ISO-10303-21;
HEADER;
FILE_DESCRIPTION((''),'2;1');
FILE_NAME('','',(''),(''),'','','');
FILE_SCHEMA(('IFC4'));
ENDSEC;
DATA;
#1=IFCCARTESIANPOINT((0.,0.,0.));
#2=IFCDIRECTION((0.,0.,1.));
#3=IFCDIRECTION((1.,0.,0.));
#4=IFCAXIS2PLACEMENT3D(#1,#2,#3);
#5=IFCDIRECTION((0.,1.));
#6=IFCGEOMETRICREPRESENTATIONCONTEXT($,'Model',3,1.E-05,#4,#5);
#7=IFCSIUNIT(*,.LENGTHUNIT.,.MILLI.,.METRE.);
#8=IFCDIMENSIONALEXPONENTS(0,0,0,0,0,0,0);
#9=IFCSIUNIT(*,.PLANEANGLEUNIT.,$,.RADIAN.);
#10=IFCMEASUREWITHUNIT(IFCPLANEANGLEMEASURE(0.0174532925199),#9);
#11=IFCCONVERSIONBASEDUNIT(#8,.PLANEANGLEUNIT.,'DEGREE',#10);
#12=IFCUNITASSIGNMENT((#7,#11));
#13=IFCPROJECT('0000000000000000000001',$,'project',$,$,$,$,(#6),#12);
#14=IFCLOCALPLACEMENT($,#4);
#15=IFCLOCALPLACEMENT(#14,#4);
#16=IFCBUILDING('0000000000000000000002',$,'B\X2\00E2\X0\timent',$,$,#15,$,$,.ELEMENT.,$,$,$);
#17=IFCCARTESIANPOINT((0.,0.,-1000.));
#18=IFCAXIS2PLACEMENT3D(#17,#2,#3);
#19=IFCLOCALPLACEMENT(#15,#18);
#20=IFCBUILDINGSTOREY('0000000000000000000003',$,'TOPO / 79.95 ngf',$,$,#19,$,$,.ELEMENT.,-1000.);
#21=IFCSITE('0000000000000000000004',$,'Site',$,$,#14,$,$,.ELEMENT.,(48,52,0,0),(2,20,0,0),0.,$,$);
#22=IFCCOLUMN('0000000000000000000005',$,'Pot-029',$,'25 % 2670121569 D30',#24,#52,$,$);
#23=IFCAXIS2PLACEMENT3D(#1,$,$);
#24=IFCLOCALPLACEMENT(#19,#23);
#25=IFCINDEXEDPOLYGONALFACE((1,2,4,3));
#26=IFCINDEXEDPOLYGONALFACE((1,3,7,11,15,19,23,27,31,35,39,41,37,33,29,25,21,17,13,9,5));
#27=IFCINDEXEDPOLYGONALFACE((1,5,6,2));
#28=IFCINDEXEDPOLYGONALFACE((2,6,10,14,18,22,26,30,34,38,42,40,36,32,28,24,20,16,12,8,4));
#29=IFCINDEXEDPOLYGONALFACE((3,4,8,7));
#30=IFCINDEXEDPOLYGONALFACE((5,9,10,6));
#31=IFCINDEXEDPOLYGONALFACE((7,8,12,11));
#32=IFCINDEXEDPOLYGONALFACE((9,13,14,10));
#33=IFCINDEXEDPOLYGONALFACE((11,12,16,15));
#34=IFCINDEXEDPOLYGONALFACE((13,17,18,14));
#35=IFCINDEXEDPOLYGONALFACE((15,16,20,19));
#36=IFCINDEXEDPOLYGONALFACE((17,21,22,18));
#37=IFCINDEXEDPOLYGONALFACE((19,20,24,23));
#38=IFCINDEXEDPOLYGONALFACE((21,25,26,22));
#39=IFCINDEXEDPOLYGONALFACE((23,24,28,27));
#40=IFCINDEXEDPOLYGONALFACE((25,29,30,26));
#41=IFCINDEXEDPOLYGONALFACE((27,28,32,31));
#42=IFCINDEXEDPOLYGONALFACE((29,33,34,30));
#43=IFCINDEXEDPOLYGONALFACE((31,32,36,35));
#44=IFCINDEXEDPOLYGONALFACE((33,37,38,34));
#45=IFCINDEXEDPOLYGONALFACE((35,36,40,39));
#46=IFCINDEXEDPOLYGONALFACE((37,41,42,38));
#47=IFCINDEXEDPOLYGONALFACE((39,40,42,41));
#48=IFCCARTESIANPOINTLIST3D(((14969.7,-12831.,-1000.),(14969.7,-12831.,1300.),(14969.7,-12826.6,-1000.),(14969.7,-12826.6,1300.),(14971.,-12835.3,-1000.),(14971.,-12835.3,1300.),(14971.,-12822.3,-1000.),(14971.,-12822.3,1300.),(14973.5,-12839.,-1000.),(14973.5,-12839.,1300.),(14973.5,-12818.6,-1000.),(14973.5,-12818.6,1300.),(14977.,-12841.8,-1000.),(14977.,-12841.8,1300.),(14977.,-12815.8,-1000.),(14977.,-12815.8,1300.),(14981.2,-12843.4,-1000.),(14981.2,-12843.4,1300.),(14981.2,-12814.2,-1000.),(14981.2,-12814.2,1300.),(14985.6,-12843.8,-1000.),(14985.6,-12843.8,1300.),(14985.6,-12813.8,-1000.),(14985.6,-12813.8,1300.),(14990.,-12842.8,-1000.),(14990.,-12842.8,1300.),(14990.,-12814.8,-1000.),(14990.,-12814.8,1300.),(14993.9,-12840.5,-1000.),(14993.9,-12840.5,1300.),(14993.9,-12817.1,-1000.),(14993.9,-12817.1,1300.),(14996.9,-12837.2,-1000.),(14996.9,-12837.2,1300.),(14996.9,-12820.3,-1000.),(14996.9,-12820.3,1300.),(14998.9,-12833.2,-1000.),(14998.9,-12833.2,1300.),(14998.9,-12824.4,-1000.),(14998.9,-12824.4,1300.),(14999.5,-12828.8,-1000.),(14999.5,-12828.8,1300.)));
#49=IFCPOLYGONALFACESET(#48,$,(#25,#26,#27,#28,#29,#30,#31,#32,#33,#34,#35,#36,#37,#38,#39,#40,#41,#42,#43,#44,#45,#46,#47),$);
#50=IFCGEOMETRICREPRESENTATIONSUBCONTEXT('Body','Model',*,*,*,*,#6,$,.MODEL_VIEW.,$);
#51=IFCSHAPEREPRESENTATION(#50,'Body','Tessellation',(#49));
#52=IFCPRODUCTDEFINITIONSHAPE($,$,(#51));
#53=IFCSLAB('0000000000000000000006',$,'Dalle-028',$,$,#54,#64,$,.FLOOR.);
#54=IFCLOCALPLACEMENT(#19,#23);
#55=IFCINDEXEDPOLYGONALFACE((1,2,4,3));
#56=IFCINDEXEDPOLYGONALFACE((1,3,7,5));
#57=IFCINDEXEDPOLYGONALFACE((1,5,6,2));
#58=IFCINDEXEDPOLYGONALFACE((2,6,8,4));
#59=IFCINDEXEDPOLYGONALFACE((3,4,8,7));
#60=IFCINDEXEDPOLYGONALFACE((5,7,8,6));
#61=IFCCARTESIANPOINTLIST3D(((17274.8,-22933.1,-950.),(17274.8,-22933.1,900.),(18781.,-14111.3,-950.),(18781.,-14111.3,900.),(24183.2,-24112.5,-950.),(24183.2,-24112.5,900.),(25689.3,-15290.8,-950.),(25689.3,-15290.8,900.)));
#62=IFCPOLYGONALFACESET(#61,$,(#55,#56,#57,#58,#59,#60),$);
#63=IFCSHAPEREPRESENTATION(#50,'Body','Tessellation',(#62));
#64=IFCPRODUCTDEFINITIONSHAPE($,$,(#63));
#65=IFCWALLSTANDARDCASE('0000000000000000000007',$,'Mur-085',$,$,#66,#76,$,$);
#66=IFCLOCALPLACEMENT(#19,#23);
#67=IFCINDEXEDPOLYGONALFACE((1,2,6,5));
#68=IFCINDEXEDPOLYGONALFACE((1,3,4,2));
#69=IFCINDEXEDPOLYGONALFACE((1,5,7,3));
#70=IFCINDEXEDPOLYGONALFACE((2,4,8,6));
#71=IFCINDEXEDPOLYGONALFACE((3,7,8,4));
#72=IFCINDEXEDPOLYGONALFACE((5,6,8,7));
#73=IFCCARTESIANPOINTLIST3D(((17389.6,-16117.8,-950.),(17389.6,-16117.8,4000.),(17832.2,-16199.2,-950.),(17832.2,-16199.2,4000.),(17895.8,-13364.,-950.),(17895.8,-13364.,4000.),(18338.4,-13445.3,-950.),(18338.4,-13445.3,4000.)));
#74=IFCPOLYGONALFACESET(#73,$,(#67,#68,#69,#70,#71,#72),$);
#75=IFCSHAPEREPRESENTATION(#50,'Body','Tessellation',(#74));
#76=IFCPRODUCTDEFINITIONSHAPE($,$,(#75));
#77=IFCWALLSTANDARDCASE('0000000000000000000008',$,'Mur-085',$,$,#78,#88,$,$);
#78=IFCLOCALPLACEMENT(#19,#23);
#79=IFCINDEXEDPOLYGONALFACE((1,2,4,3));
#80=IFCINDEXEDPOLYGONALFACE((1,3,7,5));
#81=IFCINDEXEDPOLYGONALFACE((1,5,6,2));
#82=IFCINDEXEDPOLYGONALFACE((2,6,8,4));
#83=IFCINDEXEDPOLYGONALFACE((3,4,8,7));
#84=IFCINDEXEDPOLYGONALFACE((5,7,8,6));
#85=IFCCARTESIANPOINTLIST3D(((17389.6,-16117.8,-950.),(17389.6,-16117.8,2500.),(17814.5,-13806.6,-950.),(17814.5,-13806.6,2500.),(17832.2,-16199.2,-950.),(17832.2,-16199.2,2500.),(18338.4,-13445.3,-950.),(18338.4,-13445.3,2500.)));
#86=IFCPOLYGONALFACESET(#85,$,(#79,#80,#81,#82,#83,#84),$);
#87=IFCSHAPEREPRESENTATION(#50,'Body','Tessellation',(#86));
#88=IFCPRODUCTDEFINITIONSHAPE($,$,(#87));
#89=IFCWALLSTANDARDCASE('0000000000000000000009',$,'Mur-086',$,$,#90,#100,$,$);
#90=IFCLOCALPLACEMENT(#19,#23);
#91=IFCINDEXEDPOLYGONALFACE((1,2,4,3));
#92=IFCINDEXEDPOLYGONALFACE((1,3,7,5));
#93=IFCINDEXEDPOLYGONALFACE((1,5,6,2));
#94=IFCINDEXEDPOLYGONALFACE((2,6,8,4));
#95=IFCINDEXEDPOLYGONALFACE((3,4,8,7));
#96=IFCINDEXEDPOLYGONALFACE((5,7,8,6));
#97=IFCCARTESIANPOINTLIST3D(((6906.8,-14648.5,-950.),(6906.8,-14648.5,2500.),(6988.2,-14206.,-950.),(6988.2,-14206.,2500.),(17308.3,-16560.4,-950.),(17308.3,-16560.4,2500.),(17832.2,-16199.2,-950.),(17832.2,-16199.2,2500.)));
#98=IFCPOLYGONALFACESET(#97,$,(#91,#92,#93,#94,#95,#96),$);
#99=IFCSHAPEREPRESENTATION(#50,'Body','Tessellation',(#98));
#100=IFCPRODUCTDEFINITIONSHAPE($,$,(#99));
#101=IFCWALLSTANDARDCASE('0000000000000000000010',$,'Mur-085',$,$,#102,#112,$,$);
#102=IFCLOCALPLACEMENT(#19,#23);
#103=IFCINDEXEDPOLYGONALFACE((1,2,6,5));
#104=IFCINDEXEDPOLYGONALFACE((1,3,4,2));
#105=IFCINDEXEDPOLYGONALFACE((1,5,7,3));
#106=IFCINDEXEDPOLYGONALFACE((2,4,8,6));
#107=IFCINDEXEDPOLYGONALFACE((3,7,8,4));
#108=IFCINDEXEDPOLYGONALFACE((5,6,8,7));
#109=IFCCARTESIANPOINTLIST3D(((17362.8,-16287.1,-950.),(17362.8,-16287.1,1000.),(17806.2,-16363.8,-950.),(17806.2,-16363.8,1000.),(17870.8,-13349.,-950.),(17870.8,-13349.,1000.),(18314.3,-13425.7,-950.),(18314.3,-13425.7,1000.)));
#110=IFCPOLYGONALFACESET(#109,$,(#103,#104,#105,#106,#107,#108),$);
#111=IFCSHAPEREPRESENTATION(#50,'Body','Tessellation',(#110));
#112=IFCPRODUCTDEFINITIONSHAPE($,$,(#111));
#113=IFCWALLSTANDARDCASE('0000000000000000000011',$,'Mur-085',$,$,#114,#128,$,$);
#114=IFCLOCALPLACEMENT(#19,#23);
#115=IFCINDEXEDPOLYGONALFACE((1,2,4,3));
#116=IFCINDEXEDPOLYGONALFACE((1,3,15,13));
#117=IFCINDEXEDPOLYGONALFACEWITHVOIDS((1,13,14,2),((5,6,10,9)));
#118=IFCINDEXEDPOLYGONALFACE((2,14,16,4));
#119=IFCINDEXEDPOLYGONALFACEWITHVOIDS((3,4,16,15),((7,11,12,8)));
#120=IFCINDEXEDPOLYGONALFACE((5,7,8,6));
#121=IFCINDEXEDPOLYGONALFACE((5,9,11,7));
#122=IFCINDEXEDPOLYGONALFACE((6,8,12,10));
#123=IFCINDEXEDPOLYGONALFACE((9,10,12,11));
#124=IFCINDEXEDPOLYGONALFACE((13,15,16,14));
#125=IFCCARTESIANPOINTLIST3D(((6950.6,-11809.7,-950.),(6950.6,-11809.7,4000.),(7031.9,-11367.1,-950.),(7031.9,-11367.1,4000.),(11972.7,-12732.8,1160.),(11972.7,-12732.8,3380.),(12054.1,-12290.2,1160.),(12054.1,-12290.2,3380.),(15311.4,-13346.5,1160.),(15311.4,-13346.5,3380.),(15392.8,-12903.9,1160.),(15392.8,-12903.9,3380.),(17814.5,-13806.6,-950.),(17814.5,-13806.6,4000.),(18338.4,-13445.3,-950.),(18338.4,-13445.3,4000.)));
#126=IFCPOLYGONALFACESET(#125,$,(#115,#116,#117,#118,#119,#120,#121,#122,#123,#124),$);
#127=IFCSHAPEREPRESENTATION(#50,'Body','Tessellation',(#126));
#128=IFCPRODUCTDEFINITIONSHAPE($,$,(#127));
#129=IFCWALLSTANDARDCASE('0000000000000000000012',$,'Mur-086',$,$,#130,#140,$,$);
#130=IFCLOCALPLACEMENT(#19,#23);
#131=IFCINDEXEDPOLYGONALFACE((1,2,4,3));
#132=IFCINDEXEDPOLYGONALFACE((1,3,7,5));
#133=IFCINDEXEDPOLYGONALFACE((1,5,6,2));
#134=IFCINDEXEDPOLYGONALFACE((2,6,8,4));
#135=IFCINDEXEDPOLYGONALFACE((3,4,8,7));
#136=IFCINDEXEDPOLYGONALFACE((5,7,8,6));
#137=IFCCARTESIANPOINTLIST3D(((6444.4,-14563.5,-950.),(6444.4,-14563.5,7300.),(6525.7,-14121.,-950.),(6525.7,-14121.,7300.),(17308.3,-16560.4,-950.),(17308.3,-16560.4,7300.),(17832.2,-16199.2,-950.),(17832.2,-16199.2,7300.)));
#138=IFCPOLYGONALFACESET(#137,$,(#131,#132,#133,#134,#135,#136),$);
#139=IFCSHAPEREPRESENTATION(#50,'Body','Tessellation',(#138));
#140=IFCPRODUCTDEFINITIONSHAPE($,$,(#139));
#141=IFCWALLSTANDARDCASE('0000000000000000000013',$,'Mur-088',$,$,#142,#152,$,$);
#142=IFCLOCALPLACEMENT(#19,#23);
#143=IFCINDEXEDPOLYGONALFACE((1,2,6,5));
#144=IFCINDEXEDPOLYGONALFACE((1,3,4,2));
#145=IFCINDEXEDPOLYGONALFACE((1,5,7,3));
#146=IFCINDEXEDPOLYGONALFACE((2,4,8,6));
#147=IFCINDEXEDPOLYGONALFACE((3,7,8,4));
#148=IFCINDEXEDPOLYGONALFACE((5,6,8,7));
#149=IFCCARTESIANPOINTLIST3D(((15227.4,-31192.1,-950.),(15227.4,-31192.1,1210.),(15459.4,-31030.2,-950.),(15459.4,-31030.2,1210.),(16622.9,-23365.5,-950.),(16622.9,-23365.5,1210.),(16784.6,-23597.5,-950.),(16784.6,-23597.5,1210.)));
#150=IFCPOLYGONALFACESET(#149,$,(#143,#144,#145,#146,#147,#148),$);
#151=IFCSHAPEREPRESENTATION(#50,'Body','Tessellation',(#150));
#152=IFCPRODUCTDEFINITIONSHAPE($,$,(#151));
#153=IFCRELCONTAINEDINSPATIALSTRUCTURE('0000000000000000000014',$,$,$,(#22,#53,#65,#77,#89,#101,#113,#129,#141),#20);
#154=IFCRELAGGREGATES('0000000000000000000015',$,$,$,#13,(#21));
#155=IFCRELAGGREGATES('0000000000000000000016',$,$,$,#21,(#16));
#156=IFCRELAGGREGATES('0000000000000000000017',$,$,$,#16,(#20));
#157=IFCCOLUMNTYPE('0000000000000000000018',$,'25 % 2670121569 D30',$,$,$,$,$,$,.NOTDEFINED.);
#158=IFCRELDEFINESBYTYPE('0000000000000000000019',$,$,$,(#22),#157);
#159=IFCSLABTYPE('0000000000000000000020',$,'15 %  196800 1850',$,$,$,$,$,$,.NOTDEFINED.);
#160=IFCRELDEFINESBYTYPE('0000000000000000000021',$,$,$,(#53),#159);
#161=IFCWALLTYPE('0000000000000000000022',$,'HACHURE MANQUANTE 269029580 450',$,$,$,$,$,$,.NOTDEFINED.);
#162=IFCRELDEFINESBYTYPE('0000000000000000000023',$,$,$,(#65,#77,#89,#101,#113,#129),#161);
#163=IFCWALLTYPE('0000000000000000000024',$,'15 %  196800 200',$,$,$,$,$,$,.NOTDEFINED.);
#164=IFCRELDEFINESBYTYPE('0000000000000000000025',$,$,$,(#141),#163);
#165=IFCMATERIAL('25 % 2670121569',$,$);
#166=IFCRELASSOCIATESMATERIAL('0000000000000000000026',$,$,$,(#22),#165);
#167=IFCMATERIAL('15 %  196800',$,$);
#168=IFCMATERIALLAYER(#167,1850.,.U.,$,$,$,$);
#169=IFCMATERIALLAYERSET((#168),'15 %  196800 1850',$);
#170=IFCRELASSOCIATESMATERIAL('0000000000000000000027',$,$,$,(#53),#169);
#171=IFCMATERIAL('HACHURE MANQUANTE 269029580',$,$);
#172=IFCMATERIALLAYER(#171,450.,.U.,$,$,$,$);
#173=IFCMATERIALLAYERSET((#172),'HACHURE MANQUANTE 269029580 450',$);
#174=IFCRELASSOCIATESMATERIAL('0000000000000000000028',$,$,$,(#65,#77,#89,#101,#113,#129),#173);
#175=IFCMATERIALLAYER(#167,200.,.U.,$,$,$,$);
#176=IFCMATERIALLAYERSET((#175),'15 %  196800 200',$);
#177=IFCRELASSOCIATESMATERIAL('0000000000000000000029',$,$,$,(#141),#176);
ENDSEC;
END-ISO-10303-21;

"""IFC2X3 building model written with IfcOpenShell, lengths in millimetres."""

from ifc_helpers import new_model, entity, si_unit, converted_unit, direction, frame, origin_with_axes, origin_2d_with_axis, place, context, subcontext, project, spatial, polyline, rectangle, circle, outline, extrude, material, layer, layer_set, layer_usage, type_object, element, save


model = new_model("IFC2X3")

# Units and contexts
model_context = context("Model", 3, precision=1e-05, world=origin_with_axes(), true_north=direction((0.0, 1.0)))
body_context = subcontext(model_context, "Body", "Model", "MODEL_VIEW")
ifc_project = project(units=[si_unit("LENGTHUNIT", "METRE", prefix="MILLI"), converted_unit("PLANEANGLEUNIT", "DEGREE", entity("IfcPlaneAngleMeasure", 0.0174532925199), si_unit("PLANEANGLEUNIT", "RADIAN"), dimensions=[0, 0, 0, 0, 0, 0, 0])], contexts=[model_context])

# Site, building, storey
site_placement = place(None, origin_with_axes())
site = spatial("IfcSite", under=ifc_project, at=site_placement, Name="Site", CompositionType="ELEMENT", RefLatitude=(48, 52, 0, 0), RefLongitude=(2, 20, 0, 0), RefElevation=0.0)
building_placement = place(site_placement, origin_with_axes())
building = spatial("IfcBuilding", under=site, at=building_placement, Name="Bâtiment", CompositionType="ELEMENT")
storey_placement = place(building_placement, frame((0.0, 0.0, -1000.0), z_axis=(0.0, 0.0, 1.0), x_axis=(1.0, 0.0, 0.0)))
storey = spatial("IfcBuildingStorey", under=building, at=storey_placement, Name="TOPO / 79.95 ngf", CompositionType="ELEMENT", Elevation=-1000.0)

# Column
ifc_material_1 = material(Name="25 % 2670121569")
column_type = type_object("IfcColumnType", Name="25 % 2670121569 D30", PredefinedType="NOTDEFINED")
column_1_placement = place(storey_placement, frame((14984.5, -12828.8, -1000.0), z_axis=(0.0, 0.0, 1.0), x_axis=(1.0, 0.0, 0.0)))
element("IfcColumn", 1, at=column_1_placement, inside=storey, type_object=column_type, material=ifc_material_1, Name="Pot-029", ObjectType="25 % 2670121569 D30", context=body_context, shape_type="SweptSolid", body=[
    extrude(circle(Radius=15.0, at=origin_2d_with_axis()), origin_with_axes(), (0.0, 0.0, 1.0), 2300.0),
])

# Slab
ifc_material_2 = material(Name="15 %  196800")
ifc_layer_1 = layer(ifc_material_2, 1850.0, ventilated="UNKNOWN")
ifc_layer_set_1 = layer_set([ifc_layer_1], Name="15 %  196800 1850")
ifc_layer_usage_1 = layer_usage(ifc_layer_set_1, "AXIS3", "NEGATIVE", 1850.0)
slab_type = type_object("IfcSlabType", Name="15 %  196800 1850", PredefinedType="NOTDEFINED")
slab_placement = place(storey_placement, frame((18781.0, -14111.3, 900.0), z_axis=(0.0, 0.0, 1.0), x_axis=(1.0, 0.0, 0.0)))
element("IfcSlab", 2, at=slab_placement, inside=storey, type_object=slab_type, material=ifc_layer_usage_1, Name="Dalle-028", PredefinedType="FLOOR", context=body_context, shape_type="SweptSolid", body=[
    extrude(outline(polyline([(0.0, 0.0), (-1506.1, -8821.7), (5402.2, -10001.2), (6908.3, -1179.4), (0.0, 0.0)])), frame((0.0, 0.0, -1850.0), z_axis=(0.0, 0.0, 1.0), x_axis=(1.0, 0.0, 0.0)), (0.0, 0.0, 1.0), 1850.0),
])

# Walls
ifc_material_3 = material(Name="HACHURE MANQUANTE 269029580")
ifc_layer_2 = layer(ifc_material_3, 450.0, ventilated="UNKNOWN")
ifc_layer_set_2 = layer_set([ifc_layer_2], Name="HACHURE MANQUANTE 269029580 450")
ifc_layer_usage_2 = layer_usage(ifc_layer_set_2, "AXIS2", "POSITIVE", -450.0)
wall_type_1 = type_object("IfcWallType", Name="HACHURE MANQUANTE 269029580 450", PredefinedType="NOTDEFINED")
wall_1_placement = place(storey_placement, frame((18338.4, -13445.3, -950.0), z_axis=(0.0, 0.0, 1.0), x_axis=(-0.18078, -0.983524, 0.0)))
element("IfcWallStandardCase", 3, at=wall_1_placement, inside=storey, type_object=wall_type_1, material=ifc_layer_usage_2, Name="Mur-085", context=body_context, shape_type="SweptSolid", body=[
    extrude(outline(polyline([(0.0, -450.0), (2800.0, -450.0), (2800.0, 0.0), (0.0, 0.0), (0.0, -450.0)])), origin_with_axes(), (0.0, 0.0, 1.0), 4950.0),
])
ifc_layer_usage_3 = layer_usage(ifc_layer_set_2, "AXIS2", "POSITIVE", -450.0)
wall_2_placement = place(storey_placement, frame((18338.4, -13445.3, -950.0), z_axis=(0.0, 0.0, 1.0), x_axis=(-0.18078, -0.983524, 0.0)))
element("IfcWallStandardCase", 4, at=wall_2_placement, inside=storey, type_object=wall_type_1, material=ifc_layer_usage_3, Name="Mur-085", context=body_context, shape_type="SweptSolid", body=[
    extrude(outline(polyline([(450.0, -450.0), (2800.0, -450.0), (2800.0, 0.0), (0.0, 0.0), (450.0, -450.0)])), origin_with_axes(), (0.0, 0.0, 1.0), 3450.0),
])
ifc_layer_usage_4 = layer_usage(ifc_layer_set_2, "AXIS2", "NEGATIVE", 450.0)
wall_3_placement = place(storey_placement, frame((17832.2, -16199.2, -950.0), z_axis=(0.0, 0.0, 1.0), x_axis=(-0.983524, 0.18078, 0.0)))
element("IfcWallStandardCase", 5, at=wall_3_placement, inside=storey, type_object=wall_type_1, material=ifc_layer_usage_4, Name="Mur-086", context=body_context, shape_type="SweptSolid", body=[
    extrude(outline(polyline([(0.0, 0.0), (11025.7, 0.0), (11025.7, 450.0), (450.0, 450.0), (0.0, 0.0)])), origin_with_axes(), (0.0, 0.0, 1.0), 3450.0),
])
ifc_layer_usage_5 = layer_usage(ifc_layer_set_2, "AXIS2", "POSITIVE", -450.0)
wall_4_placement = place(storey_placement, frame((18314.3, -13425.7, -950.0), z_axis=(0.0, 0.0, 1.0), x_axis=(-0.170381, -0.985378, 0.0)))
element("IfcWallStandardCase", 6, at=wall_4_placement, inside=storey, type_object=wall_type_1, material=ifc_layer_usage_5, Name="Mur-085", context=body_context, shape_type="SweptSolid", body=[
    extrude(outline(polyline([(0.0, -450.0), (2981.7, -450.0), (2981.7, 0.0), (0.0, 0.0), (0.0, -450.0)])), origin_with_axes(), (0.0, 0.0, 1.0), 1950.0),
])

# Wall, opening
ifc_layer_usage_6 = layer_usage(ifc_layer_set_2, "AXIS2", "POSITIVE", -450.0)
wall_5_placement = place(storey_placement, frame((7031.9, -11367.1, -950.0), z_axis=(0.0, 0.0, 1.0), x_axis=(0.983524, -0.18078, 0.0)))
wall_5 = element("IfcWallStandardCase", 7, at=wall_5_placement, inside=storey, type_object=wall_type_1, material=ifc_layer_usage_6, Name="Mur-085", context=body_context, shape_type="SweptSolid", body=[
    extrude(outline(polyline([(0.0, -450.0), (11045.9, -450.0), (11495.9, 0.0), (0.0, 0.0), (0.0, -450.0)])), origin_with_axes(), (0.0, 0.0, 1.0), 4950.0),
])
opening_placement = place(wall_5_placement, frame((6803.6, 0.0, 2110.0), z_axis=(0.0, 0.0, 1.0), x_axis=(1.0, 0.0, 0.0)))
element("IfcOpeningElement", 8, at=opening_placement, cuts=wall_5, context=body_context, shape_type="SweptSolid", body=[
    extrude(rectangle(XDim=3394.6, YDim=2220.0, at=origin_2d_with_axis()), frame((0.0, 450.0, 1110.0), z_axis=(0.0, 1.0, 0.0), x_axis=(-1.0, 0.0, 0.0)), (0.0, 0.0, -1.0), 1350.0),
])

# Walls
ifc_layer_usage_7 = layer_usage(ifc_layer_set_2, "AXIS2", "NEGATIVE", 450.0)
wall_6_placement = place(storey_placement, frame((17832.2, -16199.2, -950.0), z_axis=(0.0, 0.0, 1.0), x_axis=(-0.983524, 0.18078, 0.0)))
element("IfcWallStandardCase", 9, at=wall_6_placement, inside=storey, type_object=wall_type_1, material=ifc_layer_usage_7, Name="Mur-086", context=body_context, shape_type="SweptSolid", body=[
    extrude(outline(polyline([(0.0, 0.0), (11495.9, 0.0), (11495.9, 450.0), (450.0, 450.0), (0.0, 0.0)])), origin_with_axes(), (0.0, 0.0, 1.0), 8250.0),
])
ifc_layer_3 = layer(ifc_material_2, 200.0, ventilated="UNKNOWN")
ifc_layer_set_3 = layer_set([ifc_layer_3], Name="15 %  196800 200")
ifc_layer_usage_8 = layer_usage(ifc_layer_set_3, "AXIS2", "POSITIVE", -200.0)
wall_type_2 = type_object("IfcWallType", Name="15 %  196800 200", PredefinedType="NOTDEFINED")
wall_7_placement = place(storey_placement, frame((16819.8, -23400.6, -950.0), z_axis=(0.0, 0.0, 1.0), x_axis=(-0.175525, -0.984475, 0.0)))
element("IfcWallStandardCase", 10, at=wall_7_placement, inside=storey, type_object=wall_type_2, material=ifc_layer_usage_8, Name="Mur-088", context=body_context, shape_type="SweptSolid", body=[
    extrude(outline(polyline([(0.0, -200.0), (7950.0, -200.0), (7750.0, 0.0), (200.0, 0.0), (0.0, -200.0)])), origin_with_axes(), (0.0, 0.0, 1.0), 2160.0),
])

save(model, "model.ifc")
